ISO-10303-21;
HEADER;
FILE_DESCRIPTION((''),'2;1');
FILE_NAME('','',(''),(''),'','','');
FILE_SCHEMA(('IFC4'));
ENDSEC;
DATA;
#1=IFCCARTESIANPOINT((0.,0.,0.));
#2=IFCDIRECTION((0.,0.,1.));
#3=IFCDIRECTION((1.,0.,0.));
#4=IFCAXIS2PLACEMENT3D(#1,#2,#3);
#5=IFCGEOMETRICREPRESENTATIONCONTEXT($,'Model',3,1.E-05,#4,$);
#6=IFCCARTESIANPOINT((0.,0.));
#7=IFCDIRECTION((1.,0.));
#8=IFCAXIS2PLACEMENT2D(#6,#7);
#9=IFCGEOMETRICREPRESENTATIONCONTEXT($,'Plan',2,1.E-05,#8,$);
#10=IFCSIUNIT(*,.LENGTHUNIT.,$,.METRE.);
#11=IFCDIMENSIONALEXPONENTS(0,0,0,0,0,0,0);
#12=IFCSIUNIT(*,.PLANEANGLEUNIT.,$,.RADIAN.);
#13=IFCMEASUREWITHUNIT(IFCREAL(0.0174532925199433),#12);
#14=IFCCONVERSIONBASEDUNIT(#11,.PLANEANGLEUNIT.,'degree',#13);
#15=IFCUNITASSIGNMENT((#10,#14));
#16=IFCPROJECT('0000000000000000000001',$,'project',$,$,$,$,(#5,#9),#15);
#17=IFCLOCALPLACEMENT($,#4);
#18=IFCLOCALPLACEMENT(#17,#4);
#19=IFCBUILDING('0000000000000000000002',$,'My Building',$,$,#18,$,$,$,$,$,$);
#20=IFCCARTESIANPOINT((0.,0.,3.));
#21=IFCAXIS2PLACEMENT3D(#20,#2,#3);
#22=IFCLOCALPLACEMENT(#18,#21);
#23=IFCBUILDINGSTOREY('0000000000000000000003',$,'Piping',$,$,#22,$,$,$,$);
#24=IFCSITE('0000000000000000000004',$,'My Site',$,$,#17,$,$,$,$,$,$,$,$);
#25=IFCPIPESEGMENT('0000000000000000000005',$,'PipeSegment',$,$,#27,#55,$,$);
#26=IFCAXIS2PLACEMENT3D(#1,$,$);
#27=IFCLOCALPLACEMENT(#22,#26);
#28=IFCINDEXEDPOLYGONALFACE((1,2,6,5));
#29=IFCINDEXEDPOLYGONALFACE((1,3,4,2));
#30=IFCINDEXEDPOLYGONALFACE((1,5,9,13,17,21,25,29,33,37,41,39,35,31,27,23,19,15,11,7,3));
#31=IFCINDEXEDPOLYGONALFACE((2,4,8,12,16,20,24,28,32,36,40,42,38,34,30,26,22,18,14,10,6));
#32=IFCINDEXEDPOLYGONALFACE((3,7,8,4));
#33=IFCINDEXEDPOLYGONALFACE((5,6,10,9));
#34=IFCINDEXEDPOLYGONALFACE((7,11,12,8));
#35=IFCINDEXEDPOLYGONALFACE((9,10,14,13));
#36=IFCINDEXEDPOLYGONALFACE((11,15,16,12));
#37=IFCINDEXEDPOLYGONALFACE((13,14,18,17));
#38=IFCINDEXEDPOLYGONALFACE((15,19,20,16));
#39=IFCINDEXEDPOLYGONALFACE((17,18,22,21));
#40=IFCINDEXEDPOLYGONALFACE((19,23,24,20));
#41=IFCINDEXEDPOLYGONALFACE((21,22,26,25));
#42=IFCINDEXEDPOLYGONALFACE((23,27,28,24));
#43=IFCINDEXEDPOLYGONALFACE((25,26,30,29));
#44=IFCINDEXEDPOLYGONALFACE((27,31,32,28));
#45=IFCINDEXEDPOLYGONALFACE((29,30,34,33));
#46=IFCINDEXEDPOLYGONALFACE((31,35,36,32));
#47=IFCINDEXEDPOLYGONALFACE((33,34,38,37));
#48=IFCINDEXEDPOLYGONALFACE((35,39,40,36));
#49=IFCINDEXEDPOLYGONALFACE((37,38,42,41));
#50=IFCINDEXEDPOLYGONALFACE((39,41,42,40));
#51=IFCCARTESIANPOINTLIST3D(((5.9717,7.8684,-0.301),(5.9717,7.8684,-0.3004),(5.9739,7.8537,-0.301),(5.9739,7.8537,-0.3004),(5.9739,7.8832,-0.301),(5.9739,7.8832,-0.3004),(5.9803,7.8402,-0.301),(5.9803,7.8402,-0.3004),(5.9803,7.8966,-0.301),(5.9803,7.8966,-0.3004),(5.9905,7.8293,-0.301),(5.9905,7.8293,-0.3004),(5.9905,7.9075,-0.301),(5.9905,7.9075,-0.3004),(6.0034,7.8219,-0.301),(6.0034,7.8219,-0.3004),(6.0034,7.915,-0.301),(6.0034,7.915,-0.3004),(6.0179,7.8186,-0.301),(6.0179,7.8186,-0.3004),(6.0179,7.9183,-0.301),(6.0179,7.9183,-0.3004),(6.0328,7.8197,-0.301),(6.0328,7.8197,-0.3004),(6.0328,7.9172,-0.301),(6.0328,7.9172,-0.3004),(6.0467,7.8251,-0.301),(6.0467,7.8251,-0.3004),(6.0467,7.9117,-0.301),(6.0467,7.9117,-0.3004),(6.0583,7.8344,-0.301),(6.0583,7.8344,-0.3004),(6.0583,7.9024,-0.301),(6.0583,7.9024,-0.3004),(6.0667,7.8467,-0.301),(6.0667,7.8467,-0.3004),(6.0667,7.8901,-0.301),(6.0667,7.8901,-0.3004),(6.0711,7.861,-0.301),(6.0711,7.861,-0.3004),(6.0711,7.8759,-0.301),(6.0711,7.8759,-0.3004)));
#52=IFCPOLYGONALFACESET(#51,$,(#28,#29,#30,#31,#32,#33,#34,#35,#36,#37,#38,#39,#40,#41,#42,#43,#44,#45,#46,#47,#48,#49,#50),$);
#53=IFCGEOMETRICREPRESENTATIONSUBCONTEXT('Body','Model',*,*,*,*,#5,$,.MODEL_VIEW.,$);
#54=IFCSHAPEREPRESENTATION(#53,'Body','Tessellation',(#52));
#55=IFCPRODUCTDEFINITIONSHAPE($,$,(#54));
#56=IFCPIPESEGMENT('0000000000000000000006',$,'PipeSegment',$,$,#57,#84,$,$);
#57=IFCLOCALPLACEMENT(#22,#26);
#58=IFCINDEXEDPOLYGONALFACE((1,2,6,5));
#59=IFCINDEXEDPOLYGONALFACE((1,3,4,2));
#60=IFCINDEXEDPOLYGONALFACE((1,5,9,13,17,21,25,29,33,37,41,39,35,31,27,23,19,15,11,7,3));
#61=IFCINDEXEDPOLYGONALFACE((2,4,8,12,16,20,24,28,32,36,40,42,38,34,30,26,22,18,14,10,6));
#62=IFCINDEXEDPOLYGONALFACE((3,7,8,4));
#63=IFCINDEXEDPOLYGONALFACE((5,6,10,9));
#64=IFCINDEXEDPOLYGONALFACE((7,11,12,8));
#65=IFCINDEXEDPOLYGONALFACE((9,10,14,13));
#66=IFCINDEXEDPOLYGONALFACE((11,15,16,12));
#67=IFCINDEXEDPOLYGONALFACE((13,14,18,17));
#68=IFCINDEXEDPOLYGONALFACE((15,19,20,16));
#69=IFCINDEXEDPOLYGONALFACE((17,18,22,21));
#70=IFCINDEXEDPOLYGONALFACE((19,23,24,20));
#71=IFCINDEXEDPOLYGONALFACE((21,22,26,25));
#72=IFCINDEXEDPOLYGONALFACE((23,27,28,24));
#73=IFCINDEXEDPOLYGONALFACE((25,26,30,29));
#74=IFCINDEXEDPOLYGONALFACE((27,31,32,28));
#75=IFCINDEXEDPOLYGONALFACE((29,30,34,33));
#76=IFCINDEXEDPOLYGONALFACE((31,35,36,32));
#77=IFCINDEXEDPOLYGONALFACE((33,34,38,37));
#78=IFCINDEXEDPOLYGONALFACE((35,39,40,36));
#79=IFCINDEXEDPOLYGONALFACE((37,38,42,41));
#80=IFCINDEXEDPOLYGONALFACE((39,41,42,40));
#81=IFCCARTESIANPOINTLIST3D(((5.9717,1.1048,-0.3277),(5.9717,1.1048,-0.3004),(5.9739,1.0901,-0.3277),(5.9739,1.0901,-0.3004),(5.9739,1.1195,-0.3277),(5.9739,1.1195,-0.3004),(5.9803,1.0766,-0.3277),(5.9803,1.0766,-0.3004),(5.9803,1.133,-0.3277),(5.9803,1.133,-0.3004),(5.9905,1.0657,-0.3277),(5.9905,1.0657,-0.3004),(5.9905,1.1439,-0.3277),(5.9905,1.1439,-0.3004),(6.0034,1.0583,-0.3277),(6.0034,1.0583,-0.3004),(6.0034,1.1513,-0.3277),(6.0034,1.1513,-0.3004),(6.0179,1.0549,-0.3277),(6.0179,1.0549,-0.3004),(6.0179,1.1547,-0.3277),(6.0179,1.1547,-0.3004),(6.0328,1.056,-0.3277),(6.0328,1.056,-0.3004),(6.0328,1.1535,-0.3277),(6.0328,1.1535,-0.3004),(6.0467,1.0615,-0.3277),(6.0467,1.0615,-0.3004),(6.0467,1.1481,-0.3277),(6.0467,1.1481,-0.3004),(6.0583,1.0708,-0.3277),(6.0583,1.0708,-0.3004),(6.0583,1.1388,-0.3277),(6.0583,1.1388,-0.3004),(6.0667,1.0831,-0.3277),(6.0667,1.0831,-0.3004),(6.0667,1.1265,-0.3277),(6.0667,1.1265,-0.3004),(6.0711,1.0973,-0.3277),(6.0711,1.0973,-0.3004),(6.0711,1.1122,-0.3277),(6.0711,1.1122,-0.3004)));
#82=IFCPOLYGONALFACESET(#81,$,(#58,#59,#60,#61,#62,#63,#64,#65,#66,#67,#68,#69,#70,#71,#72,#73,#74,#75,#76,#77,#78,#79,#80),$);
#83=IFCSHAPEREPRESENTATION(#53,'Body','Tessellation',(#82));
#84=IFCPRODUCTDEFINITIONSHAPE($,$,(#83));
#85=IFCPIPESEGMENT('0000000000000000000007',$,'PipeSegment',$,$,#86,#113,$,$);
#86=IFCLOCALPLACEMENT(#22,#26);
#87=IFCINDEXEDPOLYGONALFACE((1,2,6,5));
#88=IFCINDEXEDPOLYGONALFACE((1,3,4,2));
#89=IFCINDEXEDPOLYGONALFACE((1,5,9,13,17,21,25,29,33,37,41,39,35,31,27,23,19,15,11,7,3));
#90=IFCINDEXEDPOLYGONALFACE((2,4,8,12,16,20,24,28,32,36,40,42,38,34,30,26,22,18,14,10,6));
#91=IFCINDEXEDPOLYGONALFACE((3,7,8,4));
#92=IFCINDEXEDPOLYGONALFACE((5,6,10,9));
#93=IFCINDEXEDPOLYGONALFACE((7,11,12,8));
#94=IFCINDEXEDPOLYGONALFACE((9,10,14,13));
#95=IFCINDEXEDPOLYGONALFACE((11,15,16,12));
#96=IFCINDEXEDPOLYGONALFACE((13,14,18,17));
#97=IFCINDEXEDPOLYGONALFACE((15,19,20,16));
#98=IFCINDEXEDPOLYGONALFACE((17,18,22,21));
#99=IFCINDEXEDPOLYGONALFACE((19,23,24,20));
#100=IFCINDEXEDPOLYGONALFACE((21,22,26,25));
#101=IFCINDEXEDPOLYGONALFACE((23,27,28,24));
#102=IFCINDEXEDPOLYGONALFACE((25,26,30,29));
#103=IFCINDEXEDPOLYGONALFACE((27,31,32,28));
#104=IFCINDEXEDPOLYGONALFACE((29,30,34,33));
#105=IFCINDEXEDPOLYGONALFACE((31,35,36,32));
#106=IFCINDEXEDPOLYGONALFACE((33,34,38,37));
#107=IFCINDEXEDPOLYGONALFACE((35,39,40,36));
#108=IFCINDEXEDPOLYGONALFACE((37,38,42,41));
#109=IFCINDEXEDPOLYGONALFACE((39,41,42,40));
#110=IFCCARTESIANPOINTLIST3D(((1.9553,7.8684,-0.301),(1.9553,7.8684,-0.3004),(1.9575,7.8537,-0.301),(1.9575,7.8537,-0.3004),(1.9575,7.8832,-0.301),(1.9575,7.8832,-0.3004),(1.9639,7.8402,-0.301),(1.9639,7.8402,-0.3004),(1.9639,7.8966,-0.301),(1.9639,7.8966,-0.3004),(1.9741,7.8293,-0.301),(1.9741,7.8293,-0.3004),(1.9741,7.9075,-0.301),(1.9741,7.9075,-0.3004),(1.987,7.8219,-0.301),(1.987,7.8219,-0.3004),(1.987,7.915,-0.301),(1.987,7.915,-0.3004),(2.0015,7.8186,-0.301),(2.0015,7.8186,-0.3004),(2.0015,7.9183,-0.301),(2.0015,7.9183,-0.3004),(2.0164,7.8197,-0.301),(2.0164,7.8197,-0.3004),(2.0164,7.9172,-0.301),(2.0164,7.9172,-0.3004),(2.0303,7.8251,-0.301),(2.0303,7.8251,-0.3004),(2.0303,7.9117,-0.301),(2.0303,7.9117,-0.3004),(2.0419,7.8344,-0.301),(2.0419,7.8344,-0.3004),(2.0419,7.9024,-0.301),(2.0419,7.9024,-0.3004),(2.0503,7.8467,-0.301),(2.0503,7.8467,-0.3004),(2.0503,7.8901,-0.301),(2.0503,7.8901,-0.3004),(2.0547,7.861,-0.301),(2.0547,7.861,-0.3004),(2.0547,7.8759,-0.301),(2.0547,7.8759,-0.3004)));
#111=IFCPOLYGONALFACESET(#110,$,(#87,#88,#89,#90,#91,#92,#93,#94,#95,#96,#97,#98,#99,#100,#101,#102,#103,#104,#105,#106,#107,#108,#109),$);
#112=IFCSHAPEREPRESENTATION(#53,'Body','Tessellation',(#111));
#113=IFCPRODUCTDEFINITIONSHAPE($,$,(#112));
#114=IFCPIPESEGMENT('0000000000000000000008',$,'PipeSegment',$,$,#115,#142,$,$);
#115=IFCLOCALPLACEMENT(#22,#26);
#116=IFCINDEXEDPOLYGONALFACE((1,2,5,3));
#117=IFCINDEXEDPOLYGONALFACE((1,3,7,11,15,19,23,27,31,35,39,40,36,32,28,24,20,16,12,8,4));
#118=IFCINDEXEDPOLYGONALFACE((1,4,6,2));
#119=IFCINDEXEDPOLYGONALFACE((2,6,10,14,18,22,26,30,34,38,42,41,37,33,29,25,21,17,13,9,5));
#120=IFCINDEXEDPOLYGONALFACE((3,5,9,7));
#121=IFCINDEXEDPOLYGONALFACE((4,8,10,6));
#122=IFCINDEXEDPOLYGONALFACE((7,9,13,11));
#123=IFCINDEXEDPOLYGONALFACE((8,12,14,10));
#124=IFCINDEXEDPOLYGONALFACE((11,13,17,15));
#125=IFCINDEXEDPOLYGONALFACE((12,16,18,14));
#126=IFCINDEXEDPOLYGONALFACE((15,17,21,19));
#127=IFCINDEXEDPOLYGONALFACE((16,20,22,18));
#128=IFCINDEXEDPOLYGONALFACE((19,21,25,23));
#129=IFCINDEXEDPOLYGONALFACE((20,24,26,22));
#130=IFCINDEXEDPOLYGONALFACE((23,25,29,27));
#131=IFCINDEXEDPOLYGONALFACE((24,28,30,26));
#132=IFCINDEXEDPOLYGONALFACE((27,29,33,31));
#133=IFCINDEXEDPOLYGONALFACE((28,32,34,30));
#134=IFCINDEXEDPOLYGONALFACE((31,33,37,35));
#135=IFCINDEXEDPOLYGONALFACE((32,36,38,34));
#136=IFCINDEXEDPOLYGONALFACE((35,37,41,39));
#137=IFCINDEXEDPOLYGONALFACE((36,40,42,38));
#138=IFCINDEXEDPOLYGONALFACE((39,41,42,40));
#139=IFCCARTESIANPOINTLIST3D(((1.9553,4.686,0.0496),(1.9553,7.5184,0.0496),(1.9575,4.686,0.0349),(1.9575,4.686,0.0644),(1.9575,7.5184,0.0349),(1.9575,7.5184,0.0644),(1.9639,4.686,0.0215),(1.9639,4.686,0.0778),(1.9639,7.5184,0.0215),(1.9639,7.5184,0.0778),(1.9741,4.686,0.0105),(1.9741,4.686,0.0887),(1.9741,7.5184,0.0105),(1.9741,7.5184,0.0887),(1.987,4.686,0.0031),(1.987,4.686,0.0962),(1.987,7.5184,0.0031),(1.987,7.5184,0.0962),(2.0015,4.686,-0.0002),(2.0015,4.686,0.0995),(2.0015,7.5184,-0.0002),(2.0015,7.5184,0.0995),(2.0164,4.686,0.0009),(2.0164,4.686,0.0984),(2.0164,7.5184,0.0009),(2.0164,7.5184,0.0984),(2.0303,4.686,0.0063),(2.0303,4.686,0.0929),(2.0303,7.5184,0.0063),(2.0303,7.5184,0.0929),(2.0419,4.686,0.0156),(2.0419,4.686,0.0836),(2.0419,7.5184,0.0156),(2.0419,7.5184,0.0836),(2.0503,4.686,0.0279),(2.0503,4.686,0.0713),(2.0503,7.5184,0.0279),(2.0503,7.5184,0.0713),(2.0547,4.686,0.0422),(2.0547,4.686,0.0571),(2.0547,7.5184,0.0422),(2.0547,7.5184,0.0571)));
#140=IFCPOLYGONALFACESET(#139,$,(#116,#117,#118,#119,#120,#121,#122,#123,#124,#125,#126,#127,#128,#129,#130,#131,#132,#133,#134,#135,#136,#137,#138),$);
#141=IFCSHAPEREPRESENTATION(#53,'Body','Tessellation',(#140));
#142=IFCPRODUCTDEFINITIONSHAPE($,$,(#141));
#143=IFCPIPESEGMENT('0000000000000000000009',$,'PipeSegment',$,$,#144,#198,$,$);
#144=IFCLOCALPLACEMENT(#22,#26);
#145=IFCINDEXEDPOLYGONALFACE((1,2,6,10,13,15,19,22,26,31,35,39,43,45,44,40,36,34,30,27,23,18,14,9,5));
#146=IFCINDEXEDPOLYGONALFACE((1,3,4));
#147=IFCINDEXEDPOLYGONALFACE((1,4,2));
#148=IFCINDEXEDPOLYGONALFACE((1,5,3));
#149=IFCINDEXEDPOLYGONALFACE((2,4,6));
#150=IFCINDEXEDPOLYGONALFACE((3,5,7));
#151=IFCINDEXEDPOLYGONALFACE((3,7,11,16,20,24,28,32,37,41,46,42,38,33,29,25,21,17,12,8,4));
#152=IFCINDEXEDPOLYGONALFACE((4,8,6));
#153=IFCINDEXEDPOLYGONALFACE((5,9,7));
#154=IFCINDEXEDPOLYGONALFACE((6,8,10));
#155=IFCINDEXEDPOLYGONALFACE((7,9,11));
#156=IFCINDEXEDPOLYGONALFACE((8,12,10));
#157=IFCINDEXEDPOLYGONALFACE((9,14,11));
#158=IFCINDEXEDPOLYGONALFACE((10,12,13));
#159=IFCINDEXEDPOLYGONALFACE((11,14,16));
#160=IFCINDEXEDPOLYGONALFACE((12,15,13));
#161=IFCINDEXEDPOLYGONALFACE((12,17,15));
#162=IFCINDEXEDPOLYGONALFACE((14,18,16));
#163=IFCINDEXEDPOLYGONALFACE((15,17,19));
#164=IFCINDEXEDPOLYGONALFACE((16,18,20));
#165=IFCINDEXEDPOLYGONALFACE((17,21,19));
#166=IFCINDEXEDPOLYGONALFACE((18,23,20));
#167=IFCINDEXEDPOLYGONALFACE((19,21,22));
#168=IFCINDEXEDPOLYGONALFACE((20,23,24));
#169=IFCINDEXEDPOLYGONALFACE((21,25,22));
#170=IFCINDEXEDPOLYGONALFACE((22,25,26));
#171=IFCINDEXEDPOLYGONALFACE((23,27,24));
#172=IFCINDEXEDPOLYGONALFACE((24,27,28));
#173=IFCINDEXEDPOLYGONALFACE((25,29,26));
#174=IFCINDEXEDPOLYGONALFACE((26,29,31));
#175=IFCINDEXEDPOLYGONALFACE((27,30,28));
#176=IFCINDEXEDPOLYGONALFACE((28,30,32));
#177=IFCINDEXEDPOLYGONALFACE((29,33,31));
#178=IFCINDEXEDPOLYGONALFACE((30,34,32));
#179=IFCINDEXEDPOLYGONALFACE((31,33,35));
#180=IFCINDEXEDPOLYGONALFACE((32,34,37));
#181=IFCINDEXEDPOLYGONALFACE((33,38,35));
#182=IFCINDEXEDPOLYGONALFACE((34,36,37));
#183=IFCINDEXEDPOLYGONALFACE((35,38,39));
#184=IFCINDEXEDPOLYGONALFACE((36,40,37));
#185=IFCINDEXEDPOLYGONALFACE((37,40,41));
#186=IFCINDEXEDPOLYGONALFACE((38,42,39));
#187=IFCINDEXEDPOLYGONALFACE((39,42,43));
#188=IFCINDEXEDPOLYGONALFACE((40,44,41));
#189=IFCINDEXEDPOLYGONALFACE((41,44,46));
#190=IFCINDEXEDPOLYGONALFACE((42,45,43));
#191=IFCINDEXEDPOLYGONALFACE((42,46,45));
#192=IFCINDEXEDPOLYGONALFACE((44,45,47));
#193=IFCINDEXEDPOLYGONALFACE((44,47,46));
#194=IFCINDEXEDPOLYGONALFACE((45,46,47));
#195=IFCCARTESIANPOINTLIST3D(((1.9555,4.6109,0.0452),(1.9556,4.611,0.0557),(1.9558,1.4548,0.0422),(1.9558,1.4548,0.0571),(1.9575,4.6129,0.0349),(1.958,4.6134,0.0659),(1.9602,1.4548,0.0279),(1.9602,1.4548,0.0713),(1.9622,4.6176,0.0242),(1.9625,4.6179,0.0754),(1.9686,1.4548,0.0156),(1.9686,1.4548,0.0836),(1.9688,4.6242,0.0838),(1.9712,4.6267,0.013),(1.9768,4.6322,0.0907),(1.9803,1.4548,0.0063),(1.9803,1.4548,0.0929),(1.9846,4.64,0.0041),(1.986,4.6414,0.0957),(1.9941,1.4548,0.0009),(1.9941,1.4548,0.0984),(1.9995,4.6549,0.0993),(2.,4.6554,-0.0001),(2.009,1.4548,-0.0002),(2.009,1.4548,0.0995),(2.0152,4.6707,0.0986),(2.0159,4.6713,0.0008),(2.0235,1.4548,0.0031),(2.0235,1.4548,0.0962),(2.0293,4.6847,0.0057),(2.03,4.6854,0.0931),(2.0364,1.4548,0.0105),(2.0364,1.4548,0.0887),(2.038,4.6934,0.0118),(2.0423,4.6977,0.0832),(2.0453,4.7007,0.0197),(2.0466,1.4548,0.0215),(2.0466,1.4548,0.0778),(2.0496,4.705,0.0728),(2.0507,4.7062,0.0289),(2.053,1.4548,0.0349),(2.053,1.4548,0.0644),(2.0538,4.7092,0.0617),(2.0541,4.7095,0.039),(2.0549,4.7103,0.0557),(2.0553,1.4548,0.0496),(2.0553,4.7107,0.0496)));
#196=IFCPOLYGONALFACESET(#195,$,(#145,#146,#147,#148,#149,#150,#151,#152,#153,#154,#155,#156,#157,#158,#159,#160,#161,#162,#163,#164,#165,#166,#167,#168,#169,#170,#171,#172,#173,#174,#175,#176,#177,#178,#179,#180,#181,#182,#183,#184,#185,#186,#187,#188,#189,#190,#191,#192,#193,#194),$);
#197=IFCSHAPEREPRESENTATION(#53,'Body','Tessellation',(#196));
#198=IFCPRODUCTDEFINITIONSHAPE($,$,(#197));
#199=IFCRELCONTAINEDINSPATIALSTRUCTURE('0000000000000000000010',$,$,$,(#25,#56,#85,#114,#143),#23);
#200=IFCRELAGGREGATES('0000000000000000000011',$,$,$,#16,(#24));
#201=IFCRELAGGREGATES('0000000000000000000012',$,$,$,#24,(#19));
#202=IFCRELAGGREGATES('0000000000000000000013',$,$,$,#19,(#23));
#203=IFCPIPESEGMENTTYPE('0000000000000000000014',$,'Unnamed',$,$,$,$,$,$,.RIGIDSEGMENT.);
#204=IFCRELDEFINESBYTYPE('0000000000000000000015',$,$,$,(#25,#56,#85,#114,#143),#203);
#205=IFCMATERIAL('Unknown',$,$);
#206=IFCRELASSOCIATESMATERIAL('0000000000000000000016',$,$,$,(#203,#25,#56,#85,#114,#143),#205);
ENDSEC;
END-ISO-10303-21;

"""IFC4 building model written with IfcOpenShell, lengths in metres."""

from ifc_helpers import new_model, entity, si_unit, converted_unit, frame, origin_with_axes, origin_2d_with_axis, place, context, subcontext, project, spatial, circle, extrude, clip, halfspace, material, material_profile, profile_set, profile_usage, type_object, element, save


model = new_model("IFC4")

# Units and contexts
model_context = context("Model", 3, precision=1e-05, world=origin_with_axes())
plan_context = context("Plan", 2, precision=1e-05, world=origin_2d_with_axis())
body_context = subcontext(model_context, "Body", "Model", "MODEL_VIEW")
ifc_project = project(units=[si_unit("LENGTHUNIT", "METRE"), converted_unit("PLANEANGLEUNIT", "degree", entity("IfcReal", 0.0174532925199433), si_unit("PLANEANGLEUNIT", "RADIAN"), dimensions=[0, 0, 0, 0, 0, 0, 0])], contexts=[model_context, plan_context])

# Site, building, storey
site_placement = place(None, origin_with_axes())
site = spatial("IfcSite", under=ifc_project, at=site_placement, Name="My Site")
building_placement = place(site_placement, origin_with_axes())
building = spatial("IfcBuilding", under=site, at=building_placement, Name="My Building")
storey_placement = place(building_placement, frame((0.0, 0.0, 3.0), z_axis=(0.0, 0.0, 1.0), x_axis=(1.0, 0.0, 0.0)))
storey = spatial("IfcBuildingStorey", under=building, at=storey_placement, Name="Piping")

# Pipe segments
ifc_material = material(Name="Unknown")
ifc_material_profile = material_profile(ifc_material, circle(Radius=0.05))
ifc_profile_set = profile_set([ifc_material_profile])
pipe_segment_type = type_object("IfcPipeSegmentType", Name="Unnamed", PredefinedType="RIGIDSEGMENT", material=ifc_profile_set)
ifc_profile_usage_1 = profile_usage(ifc_profile_set, cardinal=5)
pipe_segment_1_placement = place(storey_placement, frame((6.0217, 7.8684, -0.3004), z_axis=(0.0, 0.0, -1.0), x_axis=(-1.0, 0.0, 0.0)))
element("IfcPipeSegment", 1, at=pipe_segment_1_placement, inside=storey, type_object=pipe_segment_type, material=ifc_profile_usage_1, Name="PipeSegment", context=body_context, shape_type="SweptSolid", body=[
    extrude(circle(Radius=0.05), origin_with_axes(), (0.0, 0.0, 1.0), 0.0007),
])
ifc_profile_usage_2 = profile_usage(ifc_profile_set, cardinal=5)
pipe_segment_2_placement = place(storey_placement, frame((6.0217, 1.1048, -0.3004), z_axis=(0.0, 0.0, -1.0), x_axis=(-1.0, 0.0, 0.0)))
element("IfcPipeSegment", 2, at=pipe_segment_2_placement, inside=storey, type_object=pipe_segment_type, material=ifc_profile_usage_2, Name="PipeSegment", context=body_context, shape_type="SweptSolid", body=[
    extrude(circle(Radius=0.05), origin_with_axes(), (0.0, 0.0, 1.0), 0.0273),
])
ifc_profile_usage_3 = profile_usage(ifc_profile_set, cardinal=5)
pipe_segment_3_placement = place(storey_placement, frame((2.0053, 7.8684, -0.3004), z_axis=(0.0, 0.0, -1.0), x_axis=(-1.0, 0.0, 0.0)))
element("IfcPipeSegment", 3, at=pipe_segment_3_placement, inside=storey, type_object=pipe_segment_type, material=ifc_profile_usage_3, Name="PipeSegment", context=body_context, shape_type="SweptSolid", body=[
    extrude(circle(Radius=0.05), origin_with_axes(), (0.0, 0.0, 1.0), 0.0007),
])
ifc_profile_usage_4 = profile_usage(ifc_profile_set, cardinal=5)
pipe_segment_4_placement = place(storey_placement, frame((2.0053, 4.686, 0.0496), z_axis=(0.0, 1.0, 0.0), x_axis=(-1.0, 0.0, 0.0)))
element("IfcPipeSegment", 4, at=pipe_segment_4_placement, inside=storey, type_object=pipe_segment_type, material=ifc_profile_usage_4, Name="PipeSegment", context=body_context, shape_type="SweptSolid", body=[
    extrude(circle(Radius=0.05), origin_with_axes(), (0.0, 0.0, 1.0), 2.8324),
])
ifc_profile_usage_5 = profile_usage(ifc_profile_set, cardinal=5)
pipe_segment_5_placement = place(storey_placement, frame((2.0053, 4.7107, 0.0496), z_axis=(0.0, -1.0, 0.000007), x_axis=(1.0, 0.0, 0.0)))
element("IfcPipeSegment", 5, at=pipe_segment_5_placement, inside=storey, type_object=pipe_segment_type, material=ifc_profile_usage_5, Name="PipeSegment", context=body_context, shape_type="Clipping", body=[
    clip(extrude(circle(Radius=0.05), origin_with_axes(), (0.0, 0.0, 1.0), 3.2559), halfspace(frame((0.05, -3.0496, 0.0), z_axis=(-0.707114, 0.000005, -0.7071), x_axis=(0.000007, 1.0, 0.0)), False)),
])

save(model, "model.ifc")
